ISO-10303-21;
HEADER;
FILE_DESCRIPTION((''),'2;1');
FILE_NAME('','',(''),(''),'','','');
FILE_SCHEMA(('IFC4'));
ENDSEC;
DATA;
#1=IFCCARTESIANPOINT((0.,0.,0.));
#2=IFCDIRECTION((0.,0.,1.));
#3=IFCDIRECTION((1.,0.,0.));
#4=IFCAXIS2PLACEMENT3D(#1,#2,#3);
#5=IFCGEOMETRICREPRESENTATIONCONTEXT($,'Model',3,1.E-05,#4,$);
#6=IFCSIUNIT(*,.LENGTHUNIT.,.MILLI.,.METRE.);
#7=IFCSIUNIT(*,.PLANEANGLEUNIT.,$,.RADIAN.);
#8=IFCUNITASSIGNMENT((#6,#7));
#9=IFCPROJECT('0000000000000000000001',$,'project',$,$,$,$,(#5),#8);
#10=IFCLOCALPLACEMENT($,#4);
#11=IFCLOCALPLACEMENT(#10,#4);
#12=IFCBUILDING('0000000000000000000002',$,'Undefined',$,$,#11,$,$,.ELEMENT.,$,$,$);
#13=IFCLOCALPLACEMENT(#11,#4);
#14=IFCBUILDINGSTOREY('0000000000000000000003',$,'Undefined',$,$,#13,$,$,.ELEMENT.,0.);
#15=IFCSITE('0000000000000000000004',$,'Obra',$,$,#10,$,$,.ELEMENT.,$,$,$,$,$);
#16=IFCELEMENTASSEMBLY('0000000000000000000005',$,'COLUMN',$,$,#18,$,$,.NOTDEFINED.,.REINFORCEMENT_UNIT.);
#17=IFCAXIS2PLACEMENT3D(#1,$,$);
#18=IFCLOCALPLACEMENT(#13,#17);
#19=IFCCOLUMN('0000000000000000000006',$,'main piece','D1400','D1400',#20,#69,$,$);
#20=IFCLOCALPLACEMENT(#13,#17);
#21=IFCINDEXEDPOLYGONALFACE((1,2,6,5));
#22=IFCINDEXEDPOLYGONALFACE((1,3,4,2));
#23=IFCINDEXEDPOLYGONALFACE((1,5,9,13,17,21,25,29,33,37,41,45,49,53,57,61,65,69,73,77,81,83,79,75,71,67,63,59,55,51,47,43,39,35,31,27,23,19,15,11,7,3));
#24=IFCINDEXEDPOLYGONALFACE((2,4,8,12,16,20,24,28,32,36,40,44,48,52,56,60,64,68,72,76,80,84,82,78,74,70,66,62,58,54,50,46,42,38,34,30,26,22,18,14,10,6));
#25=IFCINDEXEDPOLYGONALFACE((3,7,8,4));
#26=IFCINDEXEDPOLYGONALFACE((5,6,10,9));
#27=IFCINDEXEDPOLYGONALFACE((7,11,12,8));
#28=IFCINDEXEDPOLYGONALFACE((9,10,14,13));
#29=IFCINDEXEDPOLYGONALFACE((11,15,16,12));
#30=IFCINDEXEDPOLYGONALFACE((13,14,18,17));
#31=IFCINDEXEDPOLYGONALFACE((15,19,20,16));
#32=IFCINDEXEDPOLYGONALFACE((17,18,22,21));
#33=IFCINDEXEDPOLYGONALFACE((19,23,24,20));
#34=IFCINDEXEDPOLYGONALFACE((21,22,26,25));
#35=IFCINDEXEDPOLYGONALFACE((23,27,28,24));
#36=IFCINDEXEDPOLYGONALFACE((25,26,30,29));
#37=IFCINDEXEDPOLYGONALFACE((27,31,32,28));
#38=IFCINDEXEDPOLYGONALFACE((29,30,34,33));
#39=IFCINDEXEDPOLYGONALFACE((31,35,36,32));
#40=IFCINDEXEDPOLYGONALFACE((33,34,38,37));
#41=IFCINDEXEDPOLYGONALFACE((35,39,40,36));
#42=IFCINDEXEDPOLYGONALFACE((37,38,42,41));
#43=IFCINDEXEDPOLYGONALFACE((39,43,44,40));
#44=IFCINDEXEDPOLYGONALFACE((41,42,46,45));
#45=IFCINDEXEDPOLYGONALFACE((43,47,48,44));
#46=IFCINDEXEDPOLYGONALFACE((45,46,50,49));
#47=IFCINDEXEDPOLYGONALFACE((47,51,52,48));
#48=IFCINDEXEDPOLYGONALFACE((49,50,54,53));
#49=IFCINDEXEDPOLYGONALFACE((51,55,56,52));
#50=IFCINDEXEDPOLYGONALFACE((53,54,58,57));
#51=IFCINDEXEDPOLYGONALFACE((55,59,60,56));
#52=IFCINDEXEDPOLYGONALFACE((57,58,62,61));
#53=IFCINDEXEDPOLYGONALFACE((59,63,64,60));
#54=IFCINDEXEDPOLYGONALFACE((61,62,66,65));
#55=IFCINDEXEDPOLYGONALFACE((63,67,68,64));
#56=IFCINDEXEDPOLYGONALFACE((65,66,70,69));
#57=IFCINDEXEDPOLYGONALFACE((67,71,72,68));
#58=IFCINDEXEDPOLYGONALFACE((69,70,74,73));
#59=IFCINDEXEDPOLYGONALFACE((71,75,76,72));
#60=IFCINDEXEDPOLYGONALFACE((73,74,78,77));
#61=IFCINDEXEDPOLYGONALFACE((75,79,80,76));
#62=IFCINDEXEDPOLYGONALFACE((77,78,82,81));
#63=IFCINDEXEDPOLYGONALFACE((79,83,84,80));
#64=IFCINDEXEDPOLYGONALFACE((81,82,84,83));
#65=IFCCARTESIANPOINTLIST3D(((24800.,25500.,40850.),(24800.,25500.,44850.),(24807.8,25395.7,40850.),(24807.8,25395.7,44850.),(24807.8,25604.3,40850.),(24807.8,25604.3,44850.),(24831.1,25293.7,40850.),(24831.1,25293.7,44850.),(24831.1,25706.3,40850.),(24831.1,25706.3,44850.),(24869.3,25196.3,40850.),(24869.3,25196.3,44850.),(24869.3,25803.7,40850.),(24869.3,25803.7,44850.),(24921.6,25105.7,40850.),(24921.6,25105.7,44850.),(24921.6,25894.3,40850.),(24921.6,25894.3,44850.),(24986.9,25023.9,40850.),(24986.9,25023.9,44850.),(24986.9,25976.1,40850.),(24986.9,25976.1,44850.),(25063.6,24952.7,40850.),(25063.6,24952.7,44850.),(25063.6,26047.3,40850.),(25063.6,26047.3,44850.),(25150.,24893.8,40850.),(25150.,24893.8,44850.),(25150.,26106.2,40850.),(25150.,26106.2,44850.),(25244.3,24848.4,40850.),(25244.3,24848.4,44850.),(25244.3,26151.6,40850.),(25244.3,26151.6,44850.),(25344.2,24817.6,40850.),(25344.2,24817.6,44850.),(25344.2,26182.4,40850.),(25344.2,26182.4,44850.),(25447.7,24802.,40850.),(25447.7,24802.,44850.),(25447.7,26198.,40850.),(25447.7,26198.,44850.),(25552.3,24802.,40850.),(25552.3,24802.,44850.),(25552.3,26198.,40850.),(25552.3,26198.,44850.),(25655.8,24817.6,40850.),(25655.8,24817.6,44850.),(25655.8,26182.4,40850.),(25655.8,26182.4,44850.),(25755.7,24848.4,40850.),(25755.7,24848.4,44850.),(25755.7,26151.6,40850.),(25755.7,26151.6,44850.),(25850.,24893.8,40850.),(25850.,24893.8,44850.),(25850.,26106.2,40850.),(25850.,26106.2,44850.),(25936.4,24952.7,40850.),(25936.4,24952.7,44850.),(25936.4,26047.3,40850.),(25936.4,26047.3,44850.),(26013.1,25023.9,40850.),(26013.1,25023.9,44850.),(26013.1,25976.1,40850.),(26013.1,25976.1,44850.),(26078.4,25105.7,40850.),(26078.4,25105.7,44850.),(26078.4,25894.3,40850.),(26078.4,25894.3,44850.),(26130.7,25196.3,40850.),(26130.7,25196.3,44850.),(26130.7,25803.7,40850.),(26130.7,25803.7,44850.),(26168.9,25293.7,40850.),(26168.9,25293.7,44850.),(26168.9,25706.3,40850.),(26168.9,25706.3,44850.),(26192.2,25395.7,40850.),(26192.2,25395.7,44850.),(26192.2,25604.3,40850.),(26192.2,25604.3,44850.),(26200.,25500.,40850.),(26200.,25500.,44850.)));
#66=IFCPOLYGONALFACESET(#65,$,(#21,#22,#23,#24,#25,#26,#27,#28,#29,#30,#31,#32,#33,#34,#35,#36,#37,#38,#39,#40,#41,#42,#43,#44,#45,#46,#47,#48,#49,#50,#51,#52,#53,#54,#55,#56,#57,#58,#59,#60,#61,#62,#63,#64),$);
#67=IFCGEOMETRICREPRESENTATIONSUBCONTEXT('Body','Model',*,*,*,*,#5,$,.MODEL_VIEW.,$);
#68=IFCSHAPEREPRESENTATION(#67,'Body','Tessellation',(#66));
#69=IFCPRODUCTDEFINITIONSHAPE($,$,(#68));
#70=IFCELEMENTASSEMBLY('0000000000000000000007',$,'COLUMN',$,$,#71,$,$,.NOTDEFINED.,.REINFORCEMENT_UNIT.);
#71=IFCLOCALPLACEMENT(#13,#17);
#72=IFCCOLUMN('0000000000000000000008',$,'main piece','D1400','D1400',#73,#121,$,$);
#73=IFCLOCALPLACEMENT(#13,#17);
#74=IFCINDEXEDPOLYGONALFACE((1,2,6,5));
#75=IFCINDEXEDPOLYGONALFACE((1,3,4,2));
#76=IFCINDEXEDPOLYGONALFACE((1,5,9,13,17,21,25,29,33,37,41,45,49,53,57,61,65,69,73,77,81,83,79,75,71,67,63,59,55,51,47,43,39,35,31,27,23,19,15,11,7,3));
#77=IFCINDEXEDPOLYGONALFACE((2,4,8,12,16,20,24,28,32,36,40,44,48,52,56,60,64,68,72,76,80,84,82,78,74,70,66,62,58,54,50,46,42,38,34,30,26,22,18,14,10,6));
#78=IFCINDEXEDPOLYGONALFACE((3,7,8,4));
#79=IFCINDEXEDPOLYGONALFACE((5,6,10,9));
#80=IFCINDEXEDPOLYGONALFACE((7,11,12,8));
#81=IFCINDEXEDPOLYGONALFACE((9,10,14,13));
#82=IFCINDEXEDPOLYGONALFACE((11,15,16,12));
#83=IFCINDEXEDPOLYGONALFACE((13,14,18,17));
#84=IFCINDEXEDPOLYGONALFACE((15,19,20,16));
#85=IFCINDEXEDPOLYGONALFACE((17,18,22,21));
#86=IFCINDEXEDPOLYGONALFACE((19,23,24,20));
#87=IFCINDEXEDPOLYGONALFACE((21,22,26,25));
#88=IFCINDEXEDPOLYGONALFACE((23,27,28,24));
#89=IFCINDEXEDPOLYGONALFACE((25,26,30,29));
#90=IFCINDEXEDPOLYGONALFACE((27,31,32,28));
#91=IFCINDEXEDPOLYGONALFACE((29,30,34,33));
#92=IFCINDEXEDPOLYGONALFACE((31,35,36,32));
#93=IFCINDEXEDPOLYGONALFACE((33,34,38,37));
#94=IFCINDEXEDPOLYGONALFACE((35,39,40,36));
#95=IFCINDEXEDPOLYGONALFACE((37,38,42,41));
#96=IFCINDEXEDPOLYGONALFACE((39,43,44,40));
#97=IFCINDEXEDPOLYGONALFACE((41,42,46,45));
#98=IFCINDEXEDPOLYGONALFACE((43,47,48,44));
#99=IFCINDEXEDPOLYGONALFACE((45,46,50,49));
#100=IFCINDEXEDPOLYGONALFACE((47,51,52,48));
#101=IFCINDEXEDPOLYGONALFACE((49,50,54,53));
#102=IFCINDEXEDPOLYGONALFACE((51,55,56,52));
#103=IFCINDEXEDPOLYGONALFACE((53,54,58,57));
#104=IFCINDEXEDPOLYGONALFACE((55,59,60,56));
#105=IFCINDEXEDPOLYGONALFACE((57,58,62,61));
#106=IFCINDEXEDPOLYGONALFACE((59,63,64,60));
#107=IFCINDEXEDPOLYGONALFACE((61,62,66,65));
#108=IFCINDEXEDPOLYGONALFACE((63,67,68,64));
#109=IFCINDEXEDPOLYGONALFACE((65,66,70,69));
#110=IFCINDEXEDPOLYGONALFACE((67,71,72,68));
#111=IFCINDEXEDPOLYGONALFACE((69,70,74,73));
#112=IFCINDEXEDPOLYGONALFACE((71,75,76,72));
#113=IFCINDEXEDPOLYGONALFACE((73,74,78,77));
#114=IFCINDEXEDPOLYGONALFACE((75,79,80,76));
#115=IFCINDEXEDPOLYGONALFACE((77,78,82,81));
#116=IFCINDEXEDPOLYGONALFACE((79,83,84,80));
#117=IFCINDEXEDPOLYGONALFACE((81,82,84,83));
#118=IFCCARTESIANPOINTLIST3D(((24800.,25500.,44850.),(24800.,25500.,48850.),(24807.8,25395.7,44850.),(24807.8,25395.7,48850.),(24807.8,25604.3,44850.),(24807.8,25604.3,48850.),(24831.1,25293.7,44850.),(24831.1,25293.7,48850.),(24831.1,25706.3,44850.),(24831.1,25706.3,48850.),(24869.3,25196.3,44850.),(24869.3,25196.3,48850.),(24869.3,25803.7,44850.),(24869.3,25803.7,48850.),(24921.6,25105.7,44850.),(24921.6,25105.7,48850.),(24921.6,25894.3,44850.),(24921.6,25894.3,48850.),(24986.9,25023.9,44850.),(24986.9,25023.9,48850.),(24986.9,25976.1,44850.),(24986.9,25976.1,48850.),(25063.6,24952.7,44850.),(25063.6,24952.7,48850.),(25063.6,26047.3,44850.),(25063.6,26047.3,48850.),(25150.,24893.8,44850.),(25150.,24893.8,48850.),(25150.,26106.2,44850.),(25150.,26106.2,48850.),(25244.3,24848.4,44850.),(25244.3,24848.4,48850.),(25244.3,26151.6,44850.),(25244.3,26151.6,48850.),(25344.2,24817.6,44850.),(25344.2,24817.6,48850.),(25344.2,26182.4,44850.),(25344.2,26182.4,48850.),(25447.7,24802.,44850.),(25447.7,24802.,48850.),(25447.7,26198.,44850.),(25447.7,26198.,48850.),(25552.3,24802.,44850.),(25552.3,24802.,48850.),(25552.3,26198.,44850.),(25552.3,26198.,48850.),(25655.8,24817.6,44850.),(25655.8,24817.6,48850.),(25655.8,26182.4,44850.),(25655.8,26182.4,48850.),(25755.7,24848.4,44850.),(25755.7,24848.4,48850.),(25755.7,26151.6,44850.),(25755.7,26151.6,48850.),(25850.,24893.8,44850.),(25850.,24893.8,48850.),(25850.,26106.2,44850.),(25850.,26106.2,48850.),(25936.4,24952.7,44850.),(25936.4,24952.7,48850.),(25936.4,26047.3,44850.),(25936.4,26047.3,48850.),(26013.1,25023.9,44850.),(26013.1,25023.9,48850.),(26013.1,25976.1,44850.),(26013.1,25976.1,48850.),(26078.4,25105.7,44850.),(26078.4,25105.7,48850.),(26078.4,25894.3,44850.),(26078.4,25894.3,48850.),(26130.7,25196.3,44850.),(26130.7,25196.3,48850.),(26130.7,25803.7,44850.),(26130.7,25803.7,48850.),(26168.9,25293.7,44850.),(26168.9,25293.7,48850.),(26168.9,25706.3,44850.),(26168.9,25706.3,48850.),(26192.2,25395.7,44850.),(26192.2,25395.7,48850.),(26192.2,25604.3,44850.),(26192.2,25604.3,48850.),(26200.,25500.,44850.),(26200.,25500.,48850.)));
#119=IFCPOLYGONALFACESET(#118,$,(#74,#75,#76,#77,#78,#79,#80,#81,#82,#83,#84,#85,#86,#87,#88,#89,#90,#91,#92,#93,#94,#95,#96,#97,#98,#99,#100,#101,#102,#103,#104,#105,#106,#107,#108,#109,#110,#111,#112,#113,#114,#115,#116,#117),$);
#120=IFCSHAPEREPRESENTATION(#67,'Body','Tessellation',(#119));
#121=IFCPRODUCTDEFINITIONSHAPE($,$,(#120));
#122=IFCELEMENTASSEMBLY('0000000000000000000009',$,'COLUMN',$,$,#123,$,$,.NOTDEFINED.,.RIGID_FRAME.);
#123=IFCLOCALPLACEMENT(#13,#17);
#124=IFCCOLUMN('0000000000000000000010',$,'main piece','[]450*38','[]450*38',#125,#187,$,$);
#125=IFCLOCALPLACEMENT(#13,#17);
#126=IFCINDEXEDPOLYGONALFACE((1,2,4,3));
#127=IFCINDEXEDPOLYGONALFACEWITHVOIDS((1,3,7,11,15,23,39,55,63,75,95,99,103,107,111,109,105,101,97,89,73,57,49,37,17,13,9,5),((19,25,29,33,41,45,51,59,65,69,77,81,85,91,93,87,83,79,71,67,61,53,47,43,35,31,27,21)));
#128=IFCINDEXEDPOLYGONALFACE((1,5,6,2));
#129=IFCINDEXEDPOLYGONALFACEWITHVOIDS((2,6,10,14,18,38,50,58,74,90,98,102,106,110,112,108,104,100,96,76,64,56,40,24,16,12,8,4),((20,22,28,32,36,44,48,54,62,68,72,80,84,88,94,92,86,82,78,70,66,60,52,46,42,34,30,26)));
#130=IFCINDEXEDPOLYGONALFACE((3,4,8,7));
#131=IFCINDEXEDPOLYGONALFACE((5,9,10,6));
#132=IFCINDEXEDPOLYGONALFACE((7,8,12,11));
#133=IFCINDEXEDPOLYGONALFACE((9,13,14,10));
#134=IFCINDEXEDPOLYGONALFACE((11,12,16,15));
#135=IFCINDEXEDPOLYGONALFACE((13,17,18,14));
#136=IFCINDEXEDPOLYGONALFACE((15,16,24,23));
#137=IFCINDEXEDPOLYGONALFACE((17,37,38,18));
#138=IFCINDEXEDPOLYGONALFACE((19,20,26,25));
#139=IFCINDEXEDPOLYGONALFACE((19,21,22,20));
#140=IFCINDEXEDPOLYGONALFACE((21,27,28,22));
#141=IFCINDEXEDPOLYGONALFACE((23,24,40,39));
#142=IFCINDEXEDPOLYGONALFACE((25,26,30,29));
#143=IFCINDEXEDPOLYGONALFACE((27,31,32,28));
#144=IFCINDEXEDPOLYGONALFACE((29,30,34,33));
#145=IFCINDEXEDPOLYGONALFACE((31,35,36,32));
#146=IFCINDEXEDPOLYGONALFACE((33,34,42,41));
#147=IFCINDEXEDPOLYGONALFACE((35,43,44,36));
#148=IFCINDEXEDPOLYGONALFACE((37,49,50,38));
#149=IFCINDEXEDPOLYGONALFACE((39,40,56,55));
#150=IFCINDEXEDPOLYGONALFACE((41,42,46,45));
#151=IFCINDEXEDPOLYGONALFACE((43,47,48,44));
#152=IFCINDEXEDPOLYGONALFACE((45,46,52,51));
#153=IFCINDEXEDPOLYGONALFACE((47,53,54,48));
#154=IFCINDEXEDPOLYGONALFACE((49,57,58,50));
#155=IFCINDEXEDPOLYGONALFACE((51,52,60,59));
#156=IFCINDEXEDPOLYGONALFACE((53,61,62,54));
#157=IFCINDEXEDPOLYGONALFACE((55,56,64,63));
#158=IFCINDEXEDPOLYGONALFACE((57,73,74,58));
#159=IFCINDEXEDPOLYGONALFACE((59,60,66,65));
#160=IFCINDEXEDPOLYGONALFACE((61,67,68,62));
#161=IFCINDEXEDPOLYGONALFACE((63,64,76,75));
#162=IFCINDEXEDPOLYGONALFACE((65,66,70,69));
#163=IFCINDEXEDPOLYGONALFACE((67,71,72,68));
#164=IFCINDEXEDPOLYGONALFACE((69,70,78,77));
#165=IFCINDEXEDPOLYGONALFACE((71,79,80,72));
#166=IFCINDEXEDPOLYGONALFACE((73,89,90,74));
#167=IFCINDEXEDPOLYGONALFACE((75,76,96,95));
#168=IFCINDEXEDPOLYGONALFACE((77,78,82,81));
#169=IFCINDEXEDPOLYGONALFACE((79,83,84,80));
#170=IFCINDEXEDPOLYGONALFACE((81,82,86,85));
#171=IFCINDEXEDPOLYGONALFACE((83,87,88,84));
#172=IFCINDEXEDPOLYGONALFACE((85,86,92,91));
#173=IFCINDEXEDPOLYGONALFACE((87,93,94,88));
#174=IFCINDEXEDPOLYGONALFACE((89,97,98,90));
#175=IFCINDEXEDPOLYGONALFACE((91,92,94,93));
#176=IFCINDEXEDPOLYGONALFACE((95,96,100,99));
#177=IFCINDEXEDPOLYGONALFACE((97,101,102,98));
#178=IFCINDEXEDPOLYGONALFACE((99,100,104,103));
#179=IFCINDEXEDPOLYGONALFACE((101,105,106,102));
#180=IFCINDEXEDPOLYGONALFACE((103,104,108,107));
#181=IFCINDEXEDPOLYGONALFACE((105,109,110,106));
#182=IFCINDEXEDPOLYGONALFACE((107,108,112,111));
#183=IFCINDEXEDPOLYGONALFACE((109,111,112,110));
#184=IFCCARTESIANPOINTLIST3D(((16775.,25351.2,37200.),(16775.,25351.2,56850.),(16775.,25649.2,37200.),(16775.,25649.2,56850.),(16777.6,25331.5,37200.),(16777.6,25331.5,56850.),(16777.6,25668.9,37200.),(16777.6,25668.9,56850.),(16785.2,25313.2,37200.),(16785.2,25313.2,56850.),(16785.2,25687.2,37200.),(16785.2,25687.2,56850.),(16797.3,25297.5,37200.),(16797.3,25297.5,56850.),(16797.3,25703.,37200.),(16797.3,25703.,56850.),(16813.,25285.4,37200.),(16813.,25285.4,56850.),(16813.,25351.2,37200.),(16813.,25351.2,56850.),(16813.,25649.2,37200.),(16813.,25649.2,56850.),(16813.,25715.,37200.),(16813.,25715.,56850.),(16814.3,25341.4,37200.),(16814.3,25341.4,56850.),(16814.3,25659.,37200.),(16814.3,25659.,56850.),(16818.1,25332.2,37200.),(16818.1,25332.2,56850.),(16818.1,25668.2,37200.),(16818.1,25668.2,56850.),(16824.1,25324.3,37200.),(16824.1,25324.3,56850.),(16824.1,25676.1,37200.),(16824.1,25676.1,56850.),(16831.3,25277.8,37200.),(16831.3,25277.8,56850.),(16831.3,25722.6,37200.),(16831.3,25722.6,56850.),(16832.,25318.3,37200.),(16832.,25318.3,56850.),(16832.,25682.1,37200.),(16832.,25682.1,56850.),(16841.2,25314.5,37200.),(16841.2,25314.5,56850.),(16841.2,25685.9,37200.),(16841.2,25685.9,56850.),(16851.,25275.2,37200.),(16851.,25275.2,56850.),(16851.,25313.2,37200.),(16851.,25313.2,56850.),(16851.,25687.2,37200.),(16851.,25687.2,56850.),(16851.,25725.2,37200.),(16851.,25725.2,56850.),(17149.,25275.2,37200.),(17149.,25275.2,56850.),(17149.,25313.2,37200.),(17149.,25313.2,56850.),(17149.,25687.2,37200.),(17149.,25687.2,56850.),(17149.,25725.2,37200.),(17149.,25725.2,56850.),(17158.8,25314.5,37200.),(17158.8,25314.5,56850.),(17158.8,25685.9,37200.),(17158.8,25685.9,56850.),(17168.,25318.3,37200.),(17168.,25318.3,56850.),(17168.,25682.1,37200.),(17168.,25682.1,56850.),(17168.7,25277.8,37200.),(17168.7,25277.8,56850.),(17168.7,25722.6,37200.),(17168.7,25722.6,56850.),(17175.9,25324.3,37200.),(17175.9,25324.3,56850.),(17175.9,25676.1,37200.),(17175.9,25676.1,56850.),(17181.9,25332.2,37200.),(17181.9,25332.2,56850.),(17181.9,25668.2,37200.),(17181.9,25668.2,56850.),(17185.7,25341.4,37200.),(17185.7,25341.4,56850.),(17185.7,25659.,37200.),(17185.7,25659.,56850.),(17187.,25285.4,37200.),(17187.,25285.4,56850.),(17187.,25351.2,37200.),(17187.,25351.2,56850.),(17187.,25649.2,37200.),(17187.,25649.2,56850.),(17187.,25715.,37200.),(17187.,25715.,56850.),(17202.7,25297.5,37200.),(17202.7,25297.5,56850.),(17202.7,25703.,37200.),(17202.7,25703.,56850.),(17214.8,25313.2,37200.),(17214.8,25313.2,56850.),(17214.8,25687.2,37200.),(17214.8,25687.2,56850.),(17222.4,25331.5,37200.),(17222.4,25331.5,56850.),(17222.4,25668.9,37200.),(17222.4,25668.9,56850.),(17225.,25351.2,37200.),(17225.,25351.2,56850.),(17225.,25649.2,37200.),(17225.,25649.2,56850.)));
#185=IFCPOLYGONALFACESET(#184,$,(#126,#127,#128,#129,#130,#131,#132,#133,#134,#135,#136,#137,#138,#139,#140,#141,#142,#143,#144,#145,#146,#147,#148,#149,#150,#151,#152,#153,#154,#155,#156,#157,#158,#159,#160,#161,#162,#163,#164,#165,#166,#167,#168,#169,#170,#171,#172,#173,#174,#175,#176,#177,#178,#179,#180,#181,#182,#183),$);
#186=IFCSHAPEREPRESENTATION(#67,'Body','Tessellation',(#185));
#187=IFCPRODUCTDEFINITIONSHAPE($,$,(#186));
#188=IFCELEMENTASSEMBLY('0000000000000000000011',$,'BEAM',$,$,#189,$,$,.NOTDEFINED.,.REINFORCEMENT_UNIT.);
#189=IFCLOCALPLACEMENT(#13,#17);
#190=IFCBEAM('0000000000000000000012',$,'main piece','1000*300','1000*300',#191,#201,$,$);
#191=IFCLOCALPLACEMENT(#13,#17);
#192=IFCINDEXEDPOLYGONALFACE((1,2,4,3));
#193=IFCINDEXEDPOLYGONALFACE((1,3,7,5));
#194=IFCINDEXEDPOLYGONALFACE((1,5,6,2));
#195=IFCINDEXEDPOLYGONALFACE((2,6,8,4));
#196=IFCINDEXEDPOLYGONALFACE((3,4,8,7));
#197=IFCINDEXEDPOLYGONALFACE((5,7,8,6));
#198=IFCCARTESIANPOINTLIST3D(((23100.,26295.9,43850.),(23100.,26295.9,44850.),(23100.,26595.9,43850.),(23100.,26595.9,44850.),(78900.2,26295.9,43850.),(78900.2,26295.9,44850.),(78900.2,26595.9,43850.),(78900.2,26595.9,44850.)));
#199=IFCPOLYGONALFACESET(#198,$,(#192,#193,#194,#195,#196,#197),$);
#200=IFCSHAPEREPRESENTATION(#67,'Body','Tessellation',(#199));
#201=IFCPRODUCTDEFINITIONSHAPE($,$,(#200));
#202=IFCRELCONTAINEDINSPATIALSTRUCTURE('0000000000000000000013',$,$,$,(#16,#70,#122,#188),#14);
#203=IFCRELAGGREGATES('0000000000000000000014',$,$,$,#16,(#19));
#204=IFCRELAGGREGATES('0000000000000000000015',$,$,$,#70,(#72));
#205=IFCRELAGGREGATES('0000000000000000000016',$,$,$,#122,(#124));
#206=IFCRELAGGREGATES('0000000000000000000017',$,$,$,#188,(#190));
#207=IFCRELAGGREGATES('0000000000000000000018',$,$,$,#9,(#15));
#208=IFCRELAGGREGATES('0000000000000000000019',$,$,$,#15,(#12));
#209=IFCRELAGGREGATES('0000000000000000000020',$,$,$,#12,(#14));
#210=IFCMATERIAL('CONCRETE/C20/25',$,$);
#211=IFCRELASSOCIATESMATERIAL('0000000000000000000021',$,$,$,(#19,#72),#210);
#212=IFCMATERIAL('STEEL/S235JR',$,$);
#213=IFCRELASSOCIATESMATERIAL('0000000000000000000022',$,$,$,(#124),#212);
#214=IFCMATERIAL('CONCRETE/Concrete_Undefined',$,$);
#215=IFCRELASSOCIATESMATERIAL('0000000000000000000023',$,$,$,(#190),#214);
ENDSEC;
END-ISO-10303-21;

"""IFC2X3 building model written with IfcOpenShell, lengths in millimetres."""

from ifc_helpers import new_model, si_unit, frame, origin_with_axes, origin_2d_with_axis, place, context, subcontext, project, spatial, rectangle, hollow_rectangle, circle, extrude, material, element, aggregate, save


model = new_model("IFC2X3")

# Units and contexts
model_context = context("Model", 3, precision=1e-05, world=origin_with_axes())
body_context = subcontext(model_context, "Body", "Model", "MODEL_VIEW")
ifc_project = project(units=[si_unit("LENGTHUNIT", "METRE", prefix="MILLI"), si_unit("PLANEANGLEUNIT", "RADIAN")], contexts=[model_context])

# Site, building, storey
site_placement = place(None, origin_with_axes())
site = spatial("IfcSite", under=ifc_project, at=site_placement, Name="Obra", CompositionType="ELEMENT")
building_placement = place(site_placement, origin_with_axes())
building = spatial("IfcBuilding", under=site, at=building_placement, Name="Undefined", CompositionType="ELEMENT")
storey_placement = place(building_placement, origin_with_axes())
storey = spatial("IfcBuildingStorey", under=building, at=storey_placement, Name="Undefined", CompositionType="ELEMENT", Elevation=0.0)

# Element assemblies, columns
assembly_1_placement = place(storey_placement, origin_with_axes())
assembly_1 = element("IfcElementAssembly", 1, at=assembly_1_placement, inside=storey, Name="COLUMN", AssemblyPlace="NOTDEFINED", PredefinedType="REINFORCEMENT_UNIT")
ifc_material_1 = material(Name="CONCRETE/C20/25")
column_1_placement = place(assembly_1_placement, frame((25500.0, 25500.0, 40850.0), z_axis=(0.0, 0.0, 1.0), x_axis=(0.0, 1.0, 0.0)))
column_1 = element("IfcColumn", 2, at=column_1_placement, material=ifc_material_1, Name="main piece", Description="D1400", ObjectType="D1400", context=body_context, shape_type="SweptSolid", body=[
    extrude(circle(Radius=700.0, at=origin_2d_with_axis()), frame((0.0, 0.0, 4000.0), z_axis=(0.0, 0.0, -1.0), x_axis=(0.0, 1.0, 0.0)), (0.0, 0.0, 1.0), 4000.0),
])
aggregate(assembly_1, [column_1])
assembly_2_placement = place(storey_placement, origin_with_axes())
assembly_2 = element("IfcElementAssembly", 3, at=assembly_2_placement, inside=storey, Name="COLUMN", AssemblyPlace="NOTDEFINED", PredefinedType="REINFORCEMENT_UNIT")
column_2_placement = place(assembly_2_placement, frame((25500.0, 25500.0, 44850.0), z_axis=(0.0, 0.0, 1.0), x_axis=(0.0, 1.0, 0.0)))
column_2 = element("IfcColumn", 4, at=column_2_placement, material=ifc_material_1, Name="main piece", Description="D1400", ObjectType="D1400", context=body_context, shape_type="SweptSolid", body=[
    extrude(circle(Radius=700.0, at=origin_2d_with_axis()), frame((0.0, 0.0, 4000.0), z_axis=(0.0, 0.0, -1.0), x_axis=(0.0, 1.0, 0.0)), (0.0, 0.0, 1.0), 4000.0),
])
aggregate(assembly_2, [column_2])
assembly_3_placement = place(storey_placement, origin_with_axes())
assembly_3 = element("IfcElementAssembly", 5, at=assembly_3_placement, inside=storey, Name="COLUMN", AssemblyPlace="NOTDEFINED", PredefinedType="RIGID_FRAME")
ifc_material_2 = material(Name="STEEL/S235JR")
column_3_placement = place(assembly_3_placement, frame((17000.0, 25500.2, 37200.0), z_axis=(0.0, 0.0, 1.0), x_axis=(0.0, 1.0, 0.0)))
column_3 = element("IfcColumn", 6, at=column_3_placement, material=ifc_material_2, Name="main piece", Description="[]450*38", ObjectType="[]450*38", context=body_context, shape_type="SweptSolid", body=[
    extrude(hollow_rectangle(XDim=450.0, YDim=450.0, WallThickness=38.0, InnerFilletRadius=38.0, OuterFilletRadius=76.0, at=origin_2d_with_axis()), frame((0.0, 0.0, 19650.0), z_axis=(0.0, 0.0, -1.0), x_axis=(0.0, 1.0, 0.0)), (0.0, 0.0, 1.0), 19650.0),
])
aggregate(assembly_3, [column_3])

# Element assembly, beam
assembly_4_placement = place(storey_placement, origin_with_axes())
assembly_4 = element("IfcElementAssembly", 7, at=assembly_4_placement, inside=storey, Name="BEAM", AssemblyPlace="NOTDEFINED", PredefinedType="REINFORCEMENT_UNIT")
ifc_material_3 = material(Name="CONCRETE/Concrete_Undefined")
beam_1_placement = place(assembly_4_placement, frame((23100.0, 26445.9, 44350.0), z_axis=(0.0, 0.0, 1.0), x_axis=(1.0, 0.0, 0.0)))
beam_1 = element("IfcBeam", 8, at=beam_1_placement, material=ifc_material_3, Name="main piece", Description="1000*300", ObjectType="1000*300", context=body_context, shape_type="SweptSolid", body=[
    extrude(rectangle(XDim=300.0, YDim=1000.0, at=origin_2d_with_axis()), frame((55800.2, 0.0, 0.0), z_axis=(-1.0, 0.0, 0.0), x_axis=(0.0, -1.0, 0.0)), (0.0, 0.0, 1.0), 55800.2),
])
aggregate(assembly_4, [beam_1])

save(model, "model.ifc")
